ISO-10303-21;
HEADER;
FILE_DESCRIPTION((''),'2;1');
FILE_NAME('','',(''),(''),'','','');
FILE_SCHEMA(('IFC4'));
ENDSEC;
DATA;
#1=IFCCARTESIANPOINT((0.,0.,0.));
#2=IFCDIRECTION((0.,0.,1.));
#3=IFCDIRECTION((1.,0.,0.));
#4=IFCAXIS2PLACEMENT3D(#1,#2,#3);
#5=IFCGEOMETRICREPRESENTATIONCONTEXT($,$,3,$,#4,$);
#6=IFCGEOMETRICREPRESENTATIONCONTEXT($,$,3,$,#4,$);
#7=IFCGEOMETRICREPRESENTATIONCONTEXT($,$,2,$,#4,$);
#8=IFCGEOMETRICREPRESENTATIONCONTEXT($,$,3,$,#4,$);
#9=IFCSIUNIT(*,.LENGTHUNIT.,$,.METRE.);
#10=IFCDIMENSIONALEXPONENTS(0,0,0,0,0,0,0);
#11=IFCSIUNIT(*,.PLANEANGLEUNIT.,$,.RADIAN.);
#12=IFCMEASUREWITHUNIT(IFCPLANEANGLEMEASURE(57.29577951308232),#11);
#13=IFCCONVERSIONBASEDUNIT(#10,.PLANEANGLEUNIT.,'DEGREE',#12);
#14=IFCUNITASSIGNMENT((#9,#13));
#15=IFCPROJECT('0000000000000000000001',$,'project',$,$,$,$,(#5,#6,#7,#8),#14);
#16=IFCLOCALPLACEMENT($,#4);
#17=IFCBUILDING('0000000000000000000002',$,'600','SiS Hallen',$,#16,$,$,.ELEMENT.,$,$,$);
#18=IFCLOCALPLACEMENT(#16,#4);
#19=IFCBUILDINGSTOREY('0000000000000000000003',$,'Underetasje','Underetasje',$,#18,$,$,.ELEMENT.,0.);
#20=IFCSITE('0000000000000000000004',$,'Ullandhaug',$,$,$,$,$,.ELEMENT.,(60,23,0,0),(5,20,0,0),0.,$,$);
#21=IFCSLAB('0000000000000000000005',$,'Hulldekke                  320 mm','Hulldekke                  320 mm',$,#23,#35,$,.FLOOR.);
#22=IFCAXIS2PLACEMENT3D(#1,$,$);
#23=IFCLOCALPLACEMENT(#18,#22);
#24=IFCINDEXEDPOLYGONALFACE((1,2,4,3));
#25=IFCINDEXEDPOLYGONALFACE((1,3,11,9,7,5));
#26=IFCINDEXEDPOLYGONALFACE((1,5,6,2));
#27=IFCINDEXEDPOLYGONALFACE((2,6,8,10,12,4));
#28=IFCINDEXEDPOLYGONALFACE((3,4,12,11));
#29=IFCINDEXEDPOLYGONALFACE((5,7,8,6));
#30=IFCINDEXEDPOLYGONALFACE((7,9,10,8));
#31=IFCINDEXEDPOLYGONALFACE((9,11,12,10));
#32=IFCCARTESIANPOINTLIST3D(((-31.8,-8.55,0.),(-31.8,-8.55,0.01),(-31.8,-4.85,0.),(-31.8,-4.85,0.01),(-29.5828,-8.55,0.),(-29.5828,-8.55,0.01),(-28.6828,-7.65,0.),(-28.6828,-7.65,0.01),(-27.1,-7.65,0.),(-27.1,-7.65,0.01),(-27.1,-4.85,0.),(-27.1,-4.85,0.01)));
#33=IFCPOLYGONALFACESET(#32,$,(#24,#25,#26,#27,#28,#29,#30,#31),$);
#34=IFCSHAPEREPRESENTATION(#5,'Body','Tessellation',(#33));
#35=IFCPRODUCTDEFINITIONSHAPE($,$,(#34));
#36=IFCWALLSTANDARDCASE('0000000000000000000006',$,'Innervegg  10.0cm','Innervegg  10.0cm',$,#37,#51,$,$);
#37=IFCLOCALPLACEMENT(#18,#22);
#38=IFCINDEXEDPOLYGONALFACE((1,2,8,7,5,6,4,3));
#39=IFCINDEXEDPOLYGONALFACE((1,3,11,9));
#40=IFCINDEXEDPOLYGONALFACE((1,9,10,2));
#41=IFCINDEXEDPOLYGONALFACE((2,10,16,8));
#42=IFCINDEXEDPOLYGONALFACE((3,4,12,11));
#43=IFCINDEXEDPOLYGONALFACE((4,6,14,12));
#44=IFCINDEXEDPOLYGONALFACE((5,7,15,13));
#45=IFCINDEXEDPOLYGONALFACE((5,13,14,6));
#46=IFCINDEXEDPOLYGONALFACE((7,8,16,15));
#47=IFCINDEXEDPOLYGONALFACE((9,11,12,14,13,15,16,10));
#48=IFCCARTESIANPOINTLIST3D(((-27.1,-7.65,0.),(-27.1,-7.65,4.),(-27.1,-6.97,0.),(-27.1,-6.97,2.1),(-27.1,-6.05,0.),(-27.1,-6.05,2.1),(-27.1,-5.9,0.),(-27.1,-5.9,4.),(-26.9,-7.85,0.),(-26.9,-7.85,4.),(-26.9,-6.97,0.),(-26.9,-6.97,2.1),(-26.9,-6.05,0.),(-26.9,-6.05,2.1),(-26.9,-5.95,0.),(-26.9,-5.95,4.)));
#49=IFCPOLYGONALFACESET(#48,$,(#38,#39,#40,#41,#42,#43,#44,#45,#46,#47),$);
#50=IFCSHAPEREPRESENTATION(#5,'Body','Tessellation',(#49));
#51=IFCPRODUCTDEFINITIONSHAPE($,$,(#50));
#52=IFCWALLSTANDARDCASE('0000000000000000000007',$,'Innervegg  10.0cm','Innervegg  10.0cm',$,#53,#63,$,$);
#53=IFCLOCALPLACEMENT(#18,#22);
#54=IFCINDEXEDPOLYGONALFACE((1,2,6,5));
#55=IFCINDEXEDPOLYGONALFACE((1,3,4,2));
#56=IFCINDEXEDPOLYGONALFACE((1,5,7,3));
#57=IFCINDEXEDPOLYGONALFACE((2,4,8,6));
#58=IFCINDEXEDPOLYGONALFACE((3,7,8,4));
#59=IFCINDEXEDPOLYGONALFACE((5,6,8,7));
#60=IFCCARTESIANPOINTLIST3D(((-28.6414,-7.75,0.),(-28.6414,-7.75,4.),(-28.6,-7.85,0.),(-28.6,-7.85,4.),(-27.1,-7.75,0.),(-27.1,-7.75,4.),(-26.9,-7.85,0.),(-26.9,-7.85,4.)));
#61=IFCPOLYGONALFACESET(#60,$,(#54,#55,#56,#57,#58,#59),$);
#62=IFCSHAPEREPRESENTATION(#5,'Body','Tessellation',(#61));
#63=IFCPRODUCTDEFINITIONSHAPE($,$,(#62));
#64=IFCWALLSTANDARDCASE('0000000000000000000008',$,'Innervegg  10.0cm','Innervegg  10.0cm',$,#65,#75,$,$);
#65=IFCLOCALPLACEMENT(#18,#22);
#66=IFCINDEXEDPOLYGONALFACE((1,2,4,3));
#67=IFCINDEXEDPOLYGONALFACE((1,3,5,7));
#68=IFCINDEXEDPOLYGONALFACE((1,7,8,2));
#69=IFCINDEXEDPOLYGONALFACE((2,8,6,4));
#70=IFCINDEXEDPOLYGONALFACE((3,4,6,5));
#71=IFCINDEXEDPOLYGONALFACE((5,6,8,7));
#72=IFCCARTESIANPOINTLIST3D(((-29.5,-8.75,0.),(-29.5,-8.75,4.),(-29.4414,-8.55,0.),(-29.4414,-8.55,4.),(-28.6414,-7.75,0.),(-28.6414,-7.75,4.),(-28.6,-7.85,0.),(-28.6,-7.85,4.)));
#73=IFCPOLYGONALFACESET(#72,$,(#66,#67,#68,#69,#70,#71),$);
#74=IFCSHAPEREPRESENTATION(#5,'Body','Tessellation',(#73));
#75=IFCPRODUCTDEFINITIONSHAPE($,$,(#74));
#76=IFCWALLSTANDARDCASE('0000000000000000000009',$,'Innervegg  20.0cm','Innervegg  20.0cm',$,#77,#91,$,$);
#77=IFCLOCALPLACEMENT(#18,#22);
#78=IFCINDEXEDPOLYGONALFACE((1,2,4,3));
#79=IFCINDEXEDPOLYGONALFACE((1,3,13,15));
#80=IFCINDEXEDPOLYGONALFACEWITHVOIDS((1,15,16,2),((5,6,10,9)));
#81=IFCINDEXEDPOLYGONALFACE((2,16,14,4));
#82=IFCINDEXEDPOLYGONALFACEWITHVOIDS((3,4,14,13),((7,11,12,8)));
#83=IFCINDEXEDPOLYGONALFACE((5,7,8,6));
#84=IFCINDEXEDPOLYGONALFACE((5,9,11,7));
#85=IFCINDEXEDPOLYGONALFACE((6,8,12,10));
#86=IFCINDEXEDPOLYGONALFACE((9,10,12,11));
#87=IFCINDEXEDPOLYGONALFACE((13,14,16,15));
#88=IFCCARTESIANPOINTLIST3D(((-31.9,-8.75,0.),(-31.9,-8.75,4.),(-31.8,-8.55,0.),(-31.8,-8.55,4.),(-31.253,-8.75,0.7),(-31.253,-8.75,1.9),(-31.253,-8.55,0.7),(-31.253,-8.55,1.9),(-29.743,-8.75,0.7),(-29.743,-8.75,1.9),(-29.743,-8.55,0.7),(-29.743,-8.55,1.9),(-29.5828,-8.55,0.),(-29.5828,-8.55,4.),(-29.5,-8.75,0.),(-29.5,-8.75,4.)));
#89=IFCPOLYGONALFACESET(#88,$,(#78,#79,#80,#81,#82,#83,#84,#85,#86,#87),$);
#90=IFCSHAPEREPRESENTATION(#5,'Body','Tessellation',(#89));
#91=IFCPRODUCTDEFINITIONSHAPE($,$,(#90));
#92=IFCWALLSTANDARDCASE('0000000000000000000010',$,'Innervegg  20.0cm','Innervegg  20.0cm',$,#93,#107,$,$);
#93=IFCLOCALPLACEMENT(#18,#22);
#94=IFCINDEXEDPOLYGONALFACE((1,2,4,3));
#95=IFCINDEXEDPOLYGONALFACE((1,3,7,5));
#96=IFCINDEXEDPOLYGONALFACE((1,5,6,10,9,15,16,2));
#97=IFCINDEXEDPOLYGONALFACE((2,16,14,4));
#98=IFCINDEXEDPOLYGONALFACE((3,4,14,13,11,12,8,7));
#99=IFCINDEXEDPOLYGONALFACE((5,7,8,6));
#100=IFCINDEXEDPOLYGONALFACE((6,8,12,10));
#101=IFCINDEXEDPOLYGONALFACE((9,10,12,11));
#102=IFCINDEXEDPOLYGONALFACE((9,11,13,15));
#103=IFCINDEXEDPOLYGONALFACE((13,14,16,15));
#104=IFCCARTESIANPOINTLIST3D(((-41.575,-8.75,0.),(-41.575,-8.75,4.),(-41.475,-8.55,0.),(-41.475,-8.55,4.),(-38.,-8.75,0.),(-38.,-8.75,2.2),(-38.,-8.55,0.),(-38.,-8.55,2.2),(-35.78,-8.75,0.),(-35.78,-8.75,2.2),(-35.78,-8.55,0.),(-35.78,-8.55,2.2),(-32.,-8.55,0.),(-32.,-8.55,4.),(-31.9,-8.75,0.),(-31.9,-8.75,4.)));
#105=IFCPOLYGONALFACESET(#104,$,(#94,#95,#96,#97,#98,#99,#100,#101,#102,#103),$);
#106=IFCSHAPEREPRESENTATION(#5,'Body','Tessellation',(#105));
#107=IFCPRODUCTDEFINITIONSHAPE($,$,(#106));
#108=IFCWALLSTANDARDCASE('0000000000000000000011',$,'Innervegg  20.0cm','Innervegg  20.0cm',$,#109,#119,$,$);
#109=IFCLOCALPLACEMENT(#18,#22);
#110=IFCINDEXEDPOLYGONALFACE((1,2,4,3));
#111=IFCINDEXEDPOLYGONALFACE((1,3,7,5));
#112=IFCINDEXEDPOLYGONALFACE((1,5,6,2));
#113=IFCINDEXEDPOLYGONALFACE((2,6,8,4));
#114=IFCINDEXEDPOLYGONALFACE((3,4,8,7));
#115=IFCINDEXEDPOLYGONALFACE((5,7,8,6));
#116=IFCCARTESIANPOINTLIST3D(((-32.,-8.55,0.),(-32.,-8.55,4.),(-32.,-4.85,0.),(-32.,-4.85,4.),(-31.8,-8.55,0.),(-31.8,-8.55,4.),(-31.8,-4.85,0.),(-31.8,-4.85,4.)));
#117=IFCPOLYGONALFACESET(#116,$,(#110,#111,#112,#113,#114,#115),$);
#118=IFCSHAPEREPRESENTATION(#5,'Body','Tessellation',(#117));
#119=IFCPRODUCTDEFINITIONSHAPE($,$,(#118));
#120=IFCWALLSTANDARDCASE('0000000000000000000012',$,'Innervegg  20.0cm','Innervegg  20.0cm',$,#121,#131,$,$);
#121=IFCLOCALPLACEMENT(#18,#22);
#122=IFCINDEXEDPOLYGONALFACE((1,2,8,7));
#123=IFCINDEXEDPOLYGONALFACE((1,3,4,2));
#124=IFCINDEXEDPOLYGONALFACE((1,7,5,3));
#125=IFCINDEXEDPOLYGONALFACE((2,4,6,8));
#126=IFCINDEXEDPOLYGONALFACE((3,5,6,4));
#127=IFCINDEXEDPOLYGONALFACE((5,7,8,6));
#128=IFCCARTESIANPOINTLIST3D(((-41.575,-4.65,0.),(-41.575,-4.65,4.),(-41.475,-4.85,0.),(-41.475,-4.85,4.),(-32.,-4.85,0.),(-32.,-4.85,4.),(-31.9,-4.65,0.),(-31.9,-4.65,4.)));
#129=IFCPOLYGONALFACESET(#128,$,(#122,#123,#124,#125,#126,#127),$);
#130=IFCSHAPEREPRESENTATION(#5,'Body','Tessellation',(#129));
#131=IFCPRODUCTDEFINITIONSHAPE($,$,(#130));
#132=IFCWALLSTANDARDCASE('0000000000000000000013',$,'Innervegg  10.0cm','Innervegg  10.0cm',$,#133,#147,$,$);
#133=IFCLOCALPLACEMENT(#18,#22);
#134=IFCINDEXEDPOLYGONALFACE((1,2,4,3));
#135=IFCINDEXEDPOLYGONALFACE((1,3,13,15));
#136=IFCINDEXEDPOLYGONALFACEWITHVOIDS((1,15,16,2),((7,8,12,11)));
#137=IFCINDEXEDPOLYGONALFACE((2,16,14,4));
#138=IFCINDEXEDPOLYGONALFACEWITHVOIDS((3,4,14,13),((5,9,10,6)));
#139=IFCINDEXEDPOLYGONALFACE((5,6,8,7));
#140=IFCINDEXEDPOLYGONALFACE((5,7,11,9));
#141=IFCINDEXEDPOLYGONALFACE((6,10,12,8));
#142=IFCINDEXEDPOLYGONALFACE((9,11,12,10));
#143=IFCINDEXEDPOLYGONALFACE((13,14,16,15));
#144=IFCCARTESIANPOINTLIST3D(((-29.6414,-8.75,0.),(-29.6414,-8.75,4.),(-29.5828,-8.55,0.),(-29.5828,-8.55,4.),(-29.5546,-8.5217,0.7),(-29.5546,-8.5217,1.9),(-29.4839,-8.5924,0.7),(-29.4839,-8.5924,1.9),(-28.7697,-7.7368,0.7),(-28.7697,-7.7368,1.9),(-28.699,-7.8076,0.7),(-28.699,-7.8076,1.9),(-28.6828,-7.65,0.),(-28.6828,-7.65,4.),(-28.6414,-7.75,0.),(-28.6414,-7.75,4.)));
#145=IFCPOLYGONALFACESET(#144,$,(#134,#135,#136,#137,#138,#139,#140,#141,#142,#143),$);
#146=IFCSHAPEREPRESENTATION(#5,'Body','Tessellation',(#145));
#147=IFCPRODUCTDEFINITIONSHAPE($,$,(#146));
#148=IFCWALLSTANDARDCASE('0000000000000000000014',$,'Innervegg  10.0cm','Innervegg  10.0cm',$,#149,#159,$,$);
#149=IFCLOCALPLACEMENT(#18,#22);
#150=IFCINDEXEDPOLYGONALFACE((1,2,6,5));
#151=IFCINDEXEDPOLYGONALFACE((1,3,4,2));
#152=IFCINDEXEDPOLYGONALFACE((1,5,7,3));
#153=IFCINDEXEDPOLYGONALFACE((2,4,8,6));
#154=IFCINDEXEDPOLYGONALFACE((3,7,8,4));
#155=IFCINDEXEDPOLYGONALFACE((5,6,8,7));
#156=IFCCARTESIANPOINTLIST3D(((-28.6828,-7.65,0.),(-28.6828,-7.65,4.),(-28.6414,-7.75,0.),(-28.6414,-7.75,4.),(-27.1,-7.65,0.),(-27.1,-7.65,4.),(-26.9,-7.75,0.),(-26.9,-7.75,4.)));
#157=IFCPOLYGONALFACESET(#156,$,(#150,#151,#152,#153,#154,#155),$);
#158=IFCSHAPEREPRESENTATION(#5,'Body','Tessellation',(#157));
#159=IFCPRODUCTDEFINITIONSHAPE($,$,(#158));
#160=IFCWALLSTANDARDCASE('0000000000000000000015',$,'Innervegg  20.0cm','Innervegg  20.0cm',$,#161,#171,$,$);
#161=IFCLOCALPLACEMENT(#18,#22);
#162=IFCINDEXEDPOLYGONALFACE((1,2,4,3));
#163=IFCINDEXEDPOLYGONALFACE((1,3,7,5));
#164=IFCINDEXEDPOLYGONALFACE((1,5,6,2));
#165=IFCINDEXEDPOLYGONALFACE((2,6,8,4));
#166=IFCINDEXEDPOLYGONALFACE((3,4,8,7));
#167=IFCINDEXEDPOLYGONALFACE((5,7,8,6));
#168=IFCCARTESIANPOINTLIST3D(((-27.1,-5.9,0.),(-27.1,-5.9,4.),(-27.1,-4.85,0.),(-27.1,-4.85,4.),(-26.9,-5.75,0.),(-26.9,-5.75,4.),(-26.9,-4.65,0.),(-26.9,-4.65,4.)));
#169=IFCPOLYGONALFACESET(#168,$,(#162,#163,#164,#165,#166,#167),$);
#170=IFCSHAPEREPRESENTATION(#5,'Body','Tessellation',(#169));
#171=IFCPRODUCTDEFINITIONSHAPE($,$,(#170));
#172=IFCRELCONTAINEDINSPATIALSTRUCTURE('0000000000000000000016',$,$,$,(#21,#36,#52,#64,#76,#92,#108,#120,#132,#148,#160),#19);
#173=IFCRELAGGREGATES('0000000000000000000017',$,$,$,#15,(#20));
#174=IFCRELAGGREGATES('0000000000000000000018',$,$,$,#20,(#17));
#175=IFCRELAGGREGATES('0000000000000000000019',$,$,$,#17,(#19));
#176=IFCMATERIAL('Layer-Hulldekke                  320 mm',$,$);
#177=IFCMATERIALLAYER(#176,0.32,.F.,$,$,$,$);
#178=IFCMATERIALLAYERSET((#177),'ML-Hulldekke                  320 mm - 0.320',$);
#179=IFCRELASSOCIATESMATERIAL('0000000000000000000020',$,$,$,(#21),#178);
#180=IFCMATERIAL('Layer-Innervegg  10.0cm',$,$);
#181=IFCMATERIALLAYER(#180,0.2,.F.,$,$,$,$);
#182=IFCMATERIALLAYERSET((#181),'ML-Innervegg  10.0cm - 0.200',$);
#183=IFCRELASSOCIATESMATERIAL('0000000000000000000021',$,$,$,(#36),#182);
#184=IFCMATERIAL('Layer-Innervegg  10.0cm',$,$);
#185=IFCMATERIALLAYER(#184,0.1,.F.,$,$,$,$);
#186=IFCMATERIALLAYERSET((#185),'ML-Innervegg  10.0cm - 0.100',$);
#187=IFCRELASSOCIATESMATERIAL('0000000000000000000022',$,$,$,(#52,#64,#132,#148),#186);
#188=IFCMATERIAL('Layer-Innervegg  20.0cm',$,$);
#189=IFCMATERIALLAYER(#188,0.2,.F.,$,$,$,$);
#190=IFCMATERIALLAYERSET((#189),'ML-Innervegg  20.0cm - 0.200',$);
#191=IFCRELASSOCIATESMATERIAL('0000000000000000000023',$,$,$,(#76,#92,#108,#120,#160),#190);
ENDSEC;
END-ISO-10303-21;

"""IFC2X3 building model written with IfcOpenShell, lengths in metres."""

from ifc_helpers import new_model, entity, si_unit, converted_unit, frame, origin_with_axes, place, context, project, spatial, polyline, outline, extrude, material, layer, layer_set, layer_usage, element, save


model = new_model("IFC2X3")

# Units and contexts
context_of_model_1 = context(None, 3, world=origin_with_axes())
context_of_model_2 = context(None, 3, world=origin_with_axes())
context_of_model_3 = context(None, 2, world=origin_with_axes())
context_of_model_4 = context(None, 3, world=origin_with_axes())
ifc_project = project(units=[si_unit("LENGTHUNIT", "METRE"), converted_unit("PLANEANGLEUNIT", "DEGREE", entity("IfcPlaneAngleMeasure", 57.29577951308232), si_unit("PLANEANGLEUNIT", "RADIAN"), dimensions=[0, 0, 0, 0, 0, 0, 0])], contexts=[context_of_model_1, context_of_model_2, context_of_model_3, context_of_model_4])

# Site, building, storey
site = spatial("IfcSite", under=ifc_project, Name="Ullandhaug", CompositionType="ELEMENT", RefLatitude=(60, 23, 0, 0), RefLongitude=(5, 20, 0, 0), RefElevation=0.0)
building_placement = place(None, origin_with_axes())
building = spatial("IfcBuilding", under=site, at=building_placement, Name="600", Description="SiS Hallen", CompositionType="ELEMENT")
storey_placement = place(building_placement, origin_with_axes())
storey = spatial("IfcBuildingStorey", under=building, at=storey_placement, Name="Underetasje", Description="Underetasje", CompositionType="ELEMENT", Elevation=0.0)

# Slab
ifc_material_1 = material(Name="Layer-Hulldekke                  320 mm")
ifc_layer_1 = layer(ifc_material_1, 0.32, ventilated=False)
ifc_layer_set_1 = layer_set([ifc_layer_1], Name="ML-Hulldekke                  320 mm - 0.320")
ifc_layer_usage_1 = layer_usage(ifc_layer_set_1, "AXIS2", "POSITIVE", 0.0)
slab_placement = place(storey_placement, frame((-31.8, -8.55, 0.0), z_axis=(0.0, 0.0, 1.0), x_axis=(1.0, 0.0, 0.0)))
element("IfcSlab", 1, at=slab_placement, inside=storey, material=ifc_layer_usage_1, Name="Hulldekke                  320 mm", Description="Hulldekke                  320 mm", PredefinedType="FLOOR", context=context_of_model_1, shape_type="SweptSolid", body=[
    extrude(outline(polyline([(0.0, 0.0), (2.2172, 0.0), (3.1172, 0.9), (4.7, 0.9), (4.7, 3.7), (0.0, 3.7), (0.0, 0.0)])), origin_with_axes(), (0.0, 0.0, 1.0), 0.01),
])

# Wall, opening
ifc_material_2 = material(Name="Layer-Innervegg  10.0cm")
ifc_layer_2 = layer(ifc_material_2, 0.2, ventilated=False)
ifc_layer_set_2 = layer_set([ifc_layer_2], Name="ML-Innervegg  10.0cm - 0.200")
ifc_layer_usage_2 = layer_usage(ifc_layer_set_2, "AXIS2", "POSITIVE", 0.0)
wall_1_placement = place(storey_placement, frame((-27.1, -5.9, 0.0), z_axis=(0.0, 0.0, 1.0), x_axis=(0.0, -1.0, 0.0)))
wall_1 = element("IfcWallStandardCase", 2, at=wall_1_placement, inside=storey, material=ifc_layer_usage_2, Name="Innervegg  10.0cm", Description="Innervegg  10.0cm", context=context_of_model_1, shape_type="SweptSolid", body=[
    extrude(outline(polyline([(0.0, 0.0), (1.75, 0.0), (1.95, 0.2), (0.05, 0.2), (0.0, 0.0)])), frame((0.0, 0.0, 0.0), z_axis=(0.0, 0.0, 1.0), x_axis=(1.0, 0.0, 0.0)), (0.0, 0.0, 1.0), 4.0),
])
opening_1_placement = place(wall_1_placement, frame((0.15, 0.2, 0.0), z_axis=(0.0, 0.0, 1.0), x_axis=(1.0, 0.0, 0.0)))
element("IfcOpeningElement", 3, at=opening_1_placement, cuts=wall_1, context=context_of_model_1, shape_type="SweptSolid", body=[
    extrude(outline(polyline([(0.0, 0.0), (2.1, 0.0), (2.1, 0.92), (0.0, 0.92), (0.0, 0.0)])), frame((0.0, 0.0, 0.0), z_axis=(0.0, 1.0, 0.0), x_axis=(0.0, 0.0, 1.0)), (0.0, 0.0, -1.0), 0.2),
])

# Walls
ifc_material_3 = material(Name="Layer-Innervegg  10.0cm")
ifc_layer_3 = layer(ifc_material_3, 0.1, ventilated=False)
ifc_layer_set_3 = layer_set([ifc_layer_3], Name="ML-Innervegg  10.0cm - 0.100")
ifc_layer_usage_3 = layer_usage(ifc_layer_set_3, "AXIS2", "POSITIVE", 0.0)
wall_2_placement = place(storey_placement, frame((-27.1, -7.75, 0.0), z_axis=(0.0, 0.0, 1.0), x_axis=(-1.0, 0.0, 0.0)))
element("IfcWallStandardCase", 4, at=wall_2_placement, inside=storey, material=ifc_layer_usage_3, Name="Innervegg  10.0cm", Description="Innervegg  10.0cm", context=context_of_model_1, shape_type="SweptSolid", body=[
    extrude(outline(polyline([(0.0, 0.0), (1.5414, 0.0), (1.5, 0.1), (-0.2, 0.1), (0.0, 0.0)])), frame((0.0, 0.0, 0.0), z_axis=(0.0, 0.0, 1.0), x_axis=(1.0, 0.0, 0.0)), (0.0, 0.0, 1.0), 4.0),
])
wall_3_placement = place(storey_placement, frame((-28.6414, -7.75, 0.0), z_axis=(0.0, 0.0, 1.0), x_axis=(-0.707107, -0.707107, 0.0)))
element("IfcWallStandardCase", 5, at=wall_3_placement, inside=storey, material=ifc_layer_usage_3, Name="Innervegg  10.0cm", Description="Innervegg  10.0cm", context=context_of_model_1, shape_type="SweptSolid", body=[
    extrude(outline(polyline([(0.0, 0.0), (1.1314, 0.0), (1.3142, 0.1), (0.0414, 0.1), (0.0, 0.0)])), frame((0.0, 0.0, 0.0), z_axis=(0.0, 0.0, 1.0), x_axis=(1.0, 0.0, 0.0)), (0.0, 0.0, 1.0), 4.0),
])

# Walls, openings
ifc_material_4 = material(Name="Layer-Innervegg  20.0cm")
ifc_layer_4 = layer(ifc_material_4, 0.2, ventilated=False)
ifc_layer_set_4 = layer_set([ifc_layer_4], Name="ML-Innervegg  20.0cm - 0.200")
ifc_layer_usage_4 = layer_usage(ifc_layer_set_4, "AXIS2", "POSITIVE", 0.0)
wall_4_placement = place(storey_placement, frame((-29.5828, -8.55, 0.0), z_axis=(0.0, 0.0, 1.0), x_axis=(-1.0, 0.0, 0.0)))
wall_4 = element("IfcWallStandardCase", 6, at=wall_4_placement, inside=storey, material=ifc_layer_usage_4, Name="Innervegg  20.0cm", Description="Innervegg  20.0cm", context=context_of_model_1, shape_type="SweptSolid", body=[
    extrude(outline(polyline([(0.0, 0.0), (2.2172, 0.0), (2.3172, 0.2), (-0.0828, 0.2), (0.0, 0.0)])), frame((0.0, 0.0, 0.0), z_axis=(0.0, 0.0, 1.0), x_axis=(1.0, 0.0, 0.0)), (0.0, 0.0, 1.0), 4.0),
])
opening_2_placement = place(wall_4_placement, frame((0.1602, 0.2, 0.7), z_axis=(0.0, 0.0, 1.0), x_axis=(1.0, 0.0, 0.0)))
element("IfcOpeningElement", 7, at=opening_2_placement, cuts=wall_4, context=context_of_model_1, shape_type="SweptSolid", body=[
    extrude(outline(polyline([(0.0, 0.0), (1.2, 0.0), (1.2, 1.51), (0.0, 1.51), (0.0, 0.0)])), frame((0.0, 0.0, 0.0), z_axis=(0.0, 1.0, 0.0), x_axis=(0.0, 0.0, 1.0)), (0.0, 0.0, -1.0), 0.2),
])
wall_5_placement = place(storey_placement, frame((-32.0, -8.55, 0.0), z_axis=(0.0, 0.0, 1.0), x_axis=(-1.0, 0.0, 0.0)))
wall_5 = element("IfcWallStandardCase", 8, at=wall_5_placement, inside=storey, material=ifc_layer_usage_4, Name="Innervegg  20.0cm", Description="Innervegg  20.0cm", context=context_of_model_1, shape_type="SweptSolid", body=[
    extrude(outline(polyline([(0.0, 0.0), (9.475, 0.0), (9.575, 0.2), (-0.1, 0.2), (0.0, 0.0)])), frame((0.0, 0.0, 0.0), z_axis=(0.0, 0.0, 1.0), x_axis=(1.0, 0.0, 0.0)), (0.0, 0.0, 1.0), 4.0),
])
opening_3_placement = place(wall_5_placement, frame((3.78, 0.2, 0.0), z_axis=(0.0, 0.0, 1.0), x_axis=(1.0, 0.0, 0.0)))
element("IfcOpeningElement", 9, at=opening_3_placement, cuts=wall_5, context=context_of_model_1, shape_type="SweptSolid", body=[
    extrude(outline(polyline([(0.0, 0.0), (2.2, 0.0), (2.2, 2.22), (0.0, 2.22), (0.0, 0.0)])), frame((0.0, 0.0, 0.0), z_axis=(0.0, 1.0, 0.0), x_axis=(0.0, 0.0, 1.0)), (0.0, 0.0, -1.0), 0.2),
])

# Walls
wall_6_placement = place(storey_placement, frame((-31.8, -8.55, 0.0), z_axis=(0.0, 0.0, 1.0), x_axis=(0.0, 1.0, 0.0)))
element("IfcWallStandardCase", 10, at=wall_6_placement, inside=storey, material=ifc_layer_usage_4, Name="Innervegg  20.0cm", Description="Innervegg  20.0cm", context=context_of_model_1, shape_type="SweptSolid", body=[
    extrude(outline(polyline([(0.0, 0.0), (3.7, 0.0), (3.7, 0.2), (0.0, 0.2), (0.0, 0.0)])), frame((0.0, 0.0, 0.0), z_axis=(0.0, 0.0, 1.0), x_axis=(1.0, 0.0, 0.0)), (0.0, 0.0, 1.0), 4.0),
])
wall_7_placement = place(storey_placement, frame((-31.9, -4.65, 0.0), z_axis=(0.0, 0.0, 1.0), x_axis=(-1.0, 0.0, 0.0)))
element("IfcWallStandardCase", 11, at=wall_7_placement, inside=storey, material=ifc_layer_usage_4, Name="Innervegg  20.0cm", Description="Innervegg  20.0cm", context=context_of_model_1, shape_type="SweptSolid", body=[
    extrude(outline(polyline([(0.0, 0.0), (9.675, 0.0), (9.575, 0.2), (0.1, 0.2), (0.0, 0.0)])), frame((0.0, 0.0, 0.0), z_axis=(0.0, 0.0, 1.0), x_axis=(1.0, 0.0, 0.0)), (0.0, 0.0, 1.0), 4.0),
])

# Wall, opening
wall_8_placement = place(storey_placement, frame((-29.6414, -8.75, 0.0), z_axis=(0.0, 0.0, 1.0), x_axis=(0.707107, 0.707107, 0.0)))
wall_8 = element("IfcWallStandardCase", 12, at=wall_8_placement, inside=storey, material=ifc_layer_usage_3, Name="Innervegg  10.0cm", Description="Innervegg  10.0cm", context=context_of_model_1, shape_type="SweptSolid", body=[
    extrude(outline(polyline([(0.0, 0.0), (1.4142, 0.0), (1.4556, 0.1), (0.1828, 0.1), (0.0, 0.0)])), frame((0.0, 0.0, 0.0), z_axis=(0.0, 0.0, 1.0), x_axis=(1.0, 0.0, 0.0)), (0.0, 0.0, 1.0), 4.0),
])
opening_4_placement = place(wall_8_placement, frame((0.2228, 0.1, 0.7), z_axis=(0.0, 0.0, 1.0), x_axis=(1.0, 0.0, 0.0)))
element("IfcOpeningElement", 13, at=opening_4_placement, cuts=wall_8, context=context_of_model_1, shape_type="SweptSolid", body=[
    extrude(outline(polyline([(0.0, 0.0), (1.2, 0.0), (1.2, 1.11), (0.0, 1.11), (0.0, 0.0)])), frame((0.0, 0.0, 0.0), z_axis=(0.0, 1.0, 0.0), x_axis=(0.0, 0.0, 1.0)), (0.0, 0.0, -1.0), 0.1),
])

# Walls
wall_9_placement = place(storey_placement, frame((-28.6414, -7.75, 0.0), z_axis=(0.0, 0.0, 1.0), x_axis=(1.0, 0.0, 0.0)))
element("IfcWallStandardCase", 14, at=wall_9_placement, inside=storey, material=ifc_layer_usage_3, Name="Innervegg  10.0cm", Description="Innervegg  10.0cm", context=context_of_model_1, shape_type="SweptSolid", body=[
    extrude(outline(polyline([(0.0, 0.0), (1.7414, 0.0), (1.5414, 0.1), (-0.0414, 0.1), (0.0, 0.0)])), origin_with_axes(), (0.0, 0.0, 1.0), 4.0),
])
wall_10_placement = place(storey_placement, frame((-26.9, -5.75, 0.0), z_axis=(0.0, 0.0, 1.0), x_axis=(0.0, 1.0, 0.0)))
element("IfcWallStandardCase", 15, at=wall_10_placement, inside=storey, material=ifc_layer_usage_4, Name="Innervegg  20.0cm", Description="Innervegg  20.0cm", context=context_of_model_1, shape_type="SweptSolid", body=[
    extrude(outline(polyline([(0.0, 0.0), (1.1, 0.0), (0.9, 0.2), (-0.15, 0.2), (0.0, 0.0)])), frame((0.0, 0.0, 0.0), z_axis=(0.0, 0.0, 1.0), x_axis=(1.0, 0.0, 0.0)), (0.0, 0.0, 1.0), 4.0),
])

save(model, "model.ifc")
